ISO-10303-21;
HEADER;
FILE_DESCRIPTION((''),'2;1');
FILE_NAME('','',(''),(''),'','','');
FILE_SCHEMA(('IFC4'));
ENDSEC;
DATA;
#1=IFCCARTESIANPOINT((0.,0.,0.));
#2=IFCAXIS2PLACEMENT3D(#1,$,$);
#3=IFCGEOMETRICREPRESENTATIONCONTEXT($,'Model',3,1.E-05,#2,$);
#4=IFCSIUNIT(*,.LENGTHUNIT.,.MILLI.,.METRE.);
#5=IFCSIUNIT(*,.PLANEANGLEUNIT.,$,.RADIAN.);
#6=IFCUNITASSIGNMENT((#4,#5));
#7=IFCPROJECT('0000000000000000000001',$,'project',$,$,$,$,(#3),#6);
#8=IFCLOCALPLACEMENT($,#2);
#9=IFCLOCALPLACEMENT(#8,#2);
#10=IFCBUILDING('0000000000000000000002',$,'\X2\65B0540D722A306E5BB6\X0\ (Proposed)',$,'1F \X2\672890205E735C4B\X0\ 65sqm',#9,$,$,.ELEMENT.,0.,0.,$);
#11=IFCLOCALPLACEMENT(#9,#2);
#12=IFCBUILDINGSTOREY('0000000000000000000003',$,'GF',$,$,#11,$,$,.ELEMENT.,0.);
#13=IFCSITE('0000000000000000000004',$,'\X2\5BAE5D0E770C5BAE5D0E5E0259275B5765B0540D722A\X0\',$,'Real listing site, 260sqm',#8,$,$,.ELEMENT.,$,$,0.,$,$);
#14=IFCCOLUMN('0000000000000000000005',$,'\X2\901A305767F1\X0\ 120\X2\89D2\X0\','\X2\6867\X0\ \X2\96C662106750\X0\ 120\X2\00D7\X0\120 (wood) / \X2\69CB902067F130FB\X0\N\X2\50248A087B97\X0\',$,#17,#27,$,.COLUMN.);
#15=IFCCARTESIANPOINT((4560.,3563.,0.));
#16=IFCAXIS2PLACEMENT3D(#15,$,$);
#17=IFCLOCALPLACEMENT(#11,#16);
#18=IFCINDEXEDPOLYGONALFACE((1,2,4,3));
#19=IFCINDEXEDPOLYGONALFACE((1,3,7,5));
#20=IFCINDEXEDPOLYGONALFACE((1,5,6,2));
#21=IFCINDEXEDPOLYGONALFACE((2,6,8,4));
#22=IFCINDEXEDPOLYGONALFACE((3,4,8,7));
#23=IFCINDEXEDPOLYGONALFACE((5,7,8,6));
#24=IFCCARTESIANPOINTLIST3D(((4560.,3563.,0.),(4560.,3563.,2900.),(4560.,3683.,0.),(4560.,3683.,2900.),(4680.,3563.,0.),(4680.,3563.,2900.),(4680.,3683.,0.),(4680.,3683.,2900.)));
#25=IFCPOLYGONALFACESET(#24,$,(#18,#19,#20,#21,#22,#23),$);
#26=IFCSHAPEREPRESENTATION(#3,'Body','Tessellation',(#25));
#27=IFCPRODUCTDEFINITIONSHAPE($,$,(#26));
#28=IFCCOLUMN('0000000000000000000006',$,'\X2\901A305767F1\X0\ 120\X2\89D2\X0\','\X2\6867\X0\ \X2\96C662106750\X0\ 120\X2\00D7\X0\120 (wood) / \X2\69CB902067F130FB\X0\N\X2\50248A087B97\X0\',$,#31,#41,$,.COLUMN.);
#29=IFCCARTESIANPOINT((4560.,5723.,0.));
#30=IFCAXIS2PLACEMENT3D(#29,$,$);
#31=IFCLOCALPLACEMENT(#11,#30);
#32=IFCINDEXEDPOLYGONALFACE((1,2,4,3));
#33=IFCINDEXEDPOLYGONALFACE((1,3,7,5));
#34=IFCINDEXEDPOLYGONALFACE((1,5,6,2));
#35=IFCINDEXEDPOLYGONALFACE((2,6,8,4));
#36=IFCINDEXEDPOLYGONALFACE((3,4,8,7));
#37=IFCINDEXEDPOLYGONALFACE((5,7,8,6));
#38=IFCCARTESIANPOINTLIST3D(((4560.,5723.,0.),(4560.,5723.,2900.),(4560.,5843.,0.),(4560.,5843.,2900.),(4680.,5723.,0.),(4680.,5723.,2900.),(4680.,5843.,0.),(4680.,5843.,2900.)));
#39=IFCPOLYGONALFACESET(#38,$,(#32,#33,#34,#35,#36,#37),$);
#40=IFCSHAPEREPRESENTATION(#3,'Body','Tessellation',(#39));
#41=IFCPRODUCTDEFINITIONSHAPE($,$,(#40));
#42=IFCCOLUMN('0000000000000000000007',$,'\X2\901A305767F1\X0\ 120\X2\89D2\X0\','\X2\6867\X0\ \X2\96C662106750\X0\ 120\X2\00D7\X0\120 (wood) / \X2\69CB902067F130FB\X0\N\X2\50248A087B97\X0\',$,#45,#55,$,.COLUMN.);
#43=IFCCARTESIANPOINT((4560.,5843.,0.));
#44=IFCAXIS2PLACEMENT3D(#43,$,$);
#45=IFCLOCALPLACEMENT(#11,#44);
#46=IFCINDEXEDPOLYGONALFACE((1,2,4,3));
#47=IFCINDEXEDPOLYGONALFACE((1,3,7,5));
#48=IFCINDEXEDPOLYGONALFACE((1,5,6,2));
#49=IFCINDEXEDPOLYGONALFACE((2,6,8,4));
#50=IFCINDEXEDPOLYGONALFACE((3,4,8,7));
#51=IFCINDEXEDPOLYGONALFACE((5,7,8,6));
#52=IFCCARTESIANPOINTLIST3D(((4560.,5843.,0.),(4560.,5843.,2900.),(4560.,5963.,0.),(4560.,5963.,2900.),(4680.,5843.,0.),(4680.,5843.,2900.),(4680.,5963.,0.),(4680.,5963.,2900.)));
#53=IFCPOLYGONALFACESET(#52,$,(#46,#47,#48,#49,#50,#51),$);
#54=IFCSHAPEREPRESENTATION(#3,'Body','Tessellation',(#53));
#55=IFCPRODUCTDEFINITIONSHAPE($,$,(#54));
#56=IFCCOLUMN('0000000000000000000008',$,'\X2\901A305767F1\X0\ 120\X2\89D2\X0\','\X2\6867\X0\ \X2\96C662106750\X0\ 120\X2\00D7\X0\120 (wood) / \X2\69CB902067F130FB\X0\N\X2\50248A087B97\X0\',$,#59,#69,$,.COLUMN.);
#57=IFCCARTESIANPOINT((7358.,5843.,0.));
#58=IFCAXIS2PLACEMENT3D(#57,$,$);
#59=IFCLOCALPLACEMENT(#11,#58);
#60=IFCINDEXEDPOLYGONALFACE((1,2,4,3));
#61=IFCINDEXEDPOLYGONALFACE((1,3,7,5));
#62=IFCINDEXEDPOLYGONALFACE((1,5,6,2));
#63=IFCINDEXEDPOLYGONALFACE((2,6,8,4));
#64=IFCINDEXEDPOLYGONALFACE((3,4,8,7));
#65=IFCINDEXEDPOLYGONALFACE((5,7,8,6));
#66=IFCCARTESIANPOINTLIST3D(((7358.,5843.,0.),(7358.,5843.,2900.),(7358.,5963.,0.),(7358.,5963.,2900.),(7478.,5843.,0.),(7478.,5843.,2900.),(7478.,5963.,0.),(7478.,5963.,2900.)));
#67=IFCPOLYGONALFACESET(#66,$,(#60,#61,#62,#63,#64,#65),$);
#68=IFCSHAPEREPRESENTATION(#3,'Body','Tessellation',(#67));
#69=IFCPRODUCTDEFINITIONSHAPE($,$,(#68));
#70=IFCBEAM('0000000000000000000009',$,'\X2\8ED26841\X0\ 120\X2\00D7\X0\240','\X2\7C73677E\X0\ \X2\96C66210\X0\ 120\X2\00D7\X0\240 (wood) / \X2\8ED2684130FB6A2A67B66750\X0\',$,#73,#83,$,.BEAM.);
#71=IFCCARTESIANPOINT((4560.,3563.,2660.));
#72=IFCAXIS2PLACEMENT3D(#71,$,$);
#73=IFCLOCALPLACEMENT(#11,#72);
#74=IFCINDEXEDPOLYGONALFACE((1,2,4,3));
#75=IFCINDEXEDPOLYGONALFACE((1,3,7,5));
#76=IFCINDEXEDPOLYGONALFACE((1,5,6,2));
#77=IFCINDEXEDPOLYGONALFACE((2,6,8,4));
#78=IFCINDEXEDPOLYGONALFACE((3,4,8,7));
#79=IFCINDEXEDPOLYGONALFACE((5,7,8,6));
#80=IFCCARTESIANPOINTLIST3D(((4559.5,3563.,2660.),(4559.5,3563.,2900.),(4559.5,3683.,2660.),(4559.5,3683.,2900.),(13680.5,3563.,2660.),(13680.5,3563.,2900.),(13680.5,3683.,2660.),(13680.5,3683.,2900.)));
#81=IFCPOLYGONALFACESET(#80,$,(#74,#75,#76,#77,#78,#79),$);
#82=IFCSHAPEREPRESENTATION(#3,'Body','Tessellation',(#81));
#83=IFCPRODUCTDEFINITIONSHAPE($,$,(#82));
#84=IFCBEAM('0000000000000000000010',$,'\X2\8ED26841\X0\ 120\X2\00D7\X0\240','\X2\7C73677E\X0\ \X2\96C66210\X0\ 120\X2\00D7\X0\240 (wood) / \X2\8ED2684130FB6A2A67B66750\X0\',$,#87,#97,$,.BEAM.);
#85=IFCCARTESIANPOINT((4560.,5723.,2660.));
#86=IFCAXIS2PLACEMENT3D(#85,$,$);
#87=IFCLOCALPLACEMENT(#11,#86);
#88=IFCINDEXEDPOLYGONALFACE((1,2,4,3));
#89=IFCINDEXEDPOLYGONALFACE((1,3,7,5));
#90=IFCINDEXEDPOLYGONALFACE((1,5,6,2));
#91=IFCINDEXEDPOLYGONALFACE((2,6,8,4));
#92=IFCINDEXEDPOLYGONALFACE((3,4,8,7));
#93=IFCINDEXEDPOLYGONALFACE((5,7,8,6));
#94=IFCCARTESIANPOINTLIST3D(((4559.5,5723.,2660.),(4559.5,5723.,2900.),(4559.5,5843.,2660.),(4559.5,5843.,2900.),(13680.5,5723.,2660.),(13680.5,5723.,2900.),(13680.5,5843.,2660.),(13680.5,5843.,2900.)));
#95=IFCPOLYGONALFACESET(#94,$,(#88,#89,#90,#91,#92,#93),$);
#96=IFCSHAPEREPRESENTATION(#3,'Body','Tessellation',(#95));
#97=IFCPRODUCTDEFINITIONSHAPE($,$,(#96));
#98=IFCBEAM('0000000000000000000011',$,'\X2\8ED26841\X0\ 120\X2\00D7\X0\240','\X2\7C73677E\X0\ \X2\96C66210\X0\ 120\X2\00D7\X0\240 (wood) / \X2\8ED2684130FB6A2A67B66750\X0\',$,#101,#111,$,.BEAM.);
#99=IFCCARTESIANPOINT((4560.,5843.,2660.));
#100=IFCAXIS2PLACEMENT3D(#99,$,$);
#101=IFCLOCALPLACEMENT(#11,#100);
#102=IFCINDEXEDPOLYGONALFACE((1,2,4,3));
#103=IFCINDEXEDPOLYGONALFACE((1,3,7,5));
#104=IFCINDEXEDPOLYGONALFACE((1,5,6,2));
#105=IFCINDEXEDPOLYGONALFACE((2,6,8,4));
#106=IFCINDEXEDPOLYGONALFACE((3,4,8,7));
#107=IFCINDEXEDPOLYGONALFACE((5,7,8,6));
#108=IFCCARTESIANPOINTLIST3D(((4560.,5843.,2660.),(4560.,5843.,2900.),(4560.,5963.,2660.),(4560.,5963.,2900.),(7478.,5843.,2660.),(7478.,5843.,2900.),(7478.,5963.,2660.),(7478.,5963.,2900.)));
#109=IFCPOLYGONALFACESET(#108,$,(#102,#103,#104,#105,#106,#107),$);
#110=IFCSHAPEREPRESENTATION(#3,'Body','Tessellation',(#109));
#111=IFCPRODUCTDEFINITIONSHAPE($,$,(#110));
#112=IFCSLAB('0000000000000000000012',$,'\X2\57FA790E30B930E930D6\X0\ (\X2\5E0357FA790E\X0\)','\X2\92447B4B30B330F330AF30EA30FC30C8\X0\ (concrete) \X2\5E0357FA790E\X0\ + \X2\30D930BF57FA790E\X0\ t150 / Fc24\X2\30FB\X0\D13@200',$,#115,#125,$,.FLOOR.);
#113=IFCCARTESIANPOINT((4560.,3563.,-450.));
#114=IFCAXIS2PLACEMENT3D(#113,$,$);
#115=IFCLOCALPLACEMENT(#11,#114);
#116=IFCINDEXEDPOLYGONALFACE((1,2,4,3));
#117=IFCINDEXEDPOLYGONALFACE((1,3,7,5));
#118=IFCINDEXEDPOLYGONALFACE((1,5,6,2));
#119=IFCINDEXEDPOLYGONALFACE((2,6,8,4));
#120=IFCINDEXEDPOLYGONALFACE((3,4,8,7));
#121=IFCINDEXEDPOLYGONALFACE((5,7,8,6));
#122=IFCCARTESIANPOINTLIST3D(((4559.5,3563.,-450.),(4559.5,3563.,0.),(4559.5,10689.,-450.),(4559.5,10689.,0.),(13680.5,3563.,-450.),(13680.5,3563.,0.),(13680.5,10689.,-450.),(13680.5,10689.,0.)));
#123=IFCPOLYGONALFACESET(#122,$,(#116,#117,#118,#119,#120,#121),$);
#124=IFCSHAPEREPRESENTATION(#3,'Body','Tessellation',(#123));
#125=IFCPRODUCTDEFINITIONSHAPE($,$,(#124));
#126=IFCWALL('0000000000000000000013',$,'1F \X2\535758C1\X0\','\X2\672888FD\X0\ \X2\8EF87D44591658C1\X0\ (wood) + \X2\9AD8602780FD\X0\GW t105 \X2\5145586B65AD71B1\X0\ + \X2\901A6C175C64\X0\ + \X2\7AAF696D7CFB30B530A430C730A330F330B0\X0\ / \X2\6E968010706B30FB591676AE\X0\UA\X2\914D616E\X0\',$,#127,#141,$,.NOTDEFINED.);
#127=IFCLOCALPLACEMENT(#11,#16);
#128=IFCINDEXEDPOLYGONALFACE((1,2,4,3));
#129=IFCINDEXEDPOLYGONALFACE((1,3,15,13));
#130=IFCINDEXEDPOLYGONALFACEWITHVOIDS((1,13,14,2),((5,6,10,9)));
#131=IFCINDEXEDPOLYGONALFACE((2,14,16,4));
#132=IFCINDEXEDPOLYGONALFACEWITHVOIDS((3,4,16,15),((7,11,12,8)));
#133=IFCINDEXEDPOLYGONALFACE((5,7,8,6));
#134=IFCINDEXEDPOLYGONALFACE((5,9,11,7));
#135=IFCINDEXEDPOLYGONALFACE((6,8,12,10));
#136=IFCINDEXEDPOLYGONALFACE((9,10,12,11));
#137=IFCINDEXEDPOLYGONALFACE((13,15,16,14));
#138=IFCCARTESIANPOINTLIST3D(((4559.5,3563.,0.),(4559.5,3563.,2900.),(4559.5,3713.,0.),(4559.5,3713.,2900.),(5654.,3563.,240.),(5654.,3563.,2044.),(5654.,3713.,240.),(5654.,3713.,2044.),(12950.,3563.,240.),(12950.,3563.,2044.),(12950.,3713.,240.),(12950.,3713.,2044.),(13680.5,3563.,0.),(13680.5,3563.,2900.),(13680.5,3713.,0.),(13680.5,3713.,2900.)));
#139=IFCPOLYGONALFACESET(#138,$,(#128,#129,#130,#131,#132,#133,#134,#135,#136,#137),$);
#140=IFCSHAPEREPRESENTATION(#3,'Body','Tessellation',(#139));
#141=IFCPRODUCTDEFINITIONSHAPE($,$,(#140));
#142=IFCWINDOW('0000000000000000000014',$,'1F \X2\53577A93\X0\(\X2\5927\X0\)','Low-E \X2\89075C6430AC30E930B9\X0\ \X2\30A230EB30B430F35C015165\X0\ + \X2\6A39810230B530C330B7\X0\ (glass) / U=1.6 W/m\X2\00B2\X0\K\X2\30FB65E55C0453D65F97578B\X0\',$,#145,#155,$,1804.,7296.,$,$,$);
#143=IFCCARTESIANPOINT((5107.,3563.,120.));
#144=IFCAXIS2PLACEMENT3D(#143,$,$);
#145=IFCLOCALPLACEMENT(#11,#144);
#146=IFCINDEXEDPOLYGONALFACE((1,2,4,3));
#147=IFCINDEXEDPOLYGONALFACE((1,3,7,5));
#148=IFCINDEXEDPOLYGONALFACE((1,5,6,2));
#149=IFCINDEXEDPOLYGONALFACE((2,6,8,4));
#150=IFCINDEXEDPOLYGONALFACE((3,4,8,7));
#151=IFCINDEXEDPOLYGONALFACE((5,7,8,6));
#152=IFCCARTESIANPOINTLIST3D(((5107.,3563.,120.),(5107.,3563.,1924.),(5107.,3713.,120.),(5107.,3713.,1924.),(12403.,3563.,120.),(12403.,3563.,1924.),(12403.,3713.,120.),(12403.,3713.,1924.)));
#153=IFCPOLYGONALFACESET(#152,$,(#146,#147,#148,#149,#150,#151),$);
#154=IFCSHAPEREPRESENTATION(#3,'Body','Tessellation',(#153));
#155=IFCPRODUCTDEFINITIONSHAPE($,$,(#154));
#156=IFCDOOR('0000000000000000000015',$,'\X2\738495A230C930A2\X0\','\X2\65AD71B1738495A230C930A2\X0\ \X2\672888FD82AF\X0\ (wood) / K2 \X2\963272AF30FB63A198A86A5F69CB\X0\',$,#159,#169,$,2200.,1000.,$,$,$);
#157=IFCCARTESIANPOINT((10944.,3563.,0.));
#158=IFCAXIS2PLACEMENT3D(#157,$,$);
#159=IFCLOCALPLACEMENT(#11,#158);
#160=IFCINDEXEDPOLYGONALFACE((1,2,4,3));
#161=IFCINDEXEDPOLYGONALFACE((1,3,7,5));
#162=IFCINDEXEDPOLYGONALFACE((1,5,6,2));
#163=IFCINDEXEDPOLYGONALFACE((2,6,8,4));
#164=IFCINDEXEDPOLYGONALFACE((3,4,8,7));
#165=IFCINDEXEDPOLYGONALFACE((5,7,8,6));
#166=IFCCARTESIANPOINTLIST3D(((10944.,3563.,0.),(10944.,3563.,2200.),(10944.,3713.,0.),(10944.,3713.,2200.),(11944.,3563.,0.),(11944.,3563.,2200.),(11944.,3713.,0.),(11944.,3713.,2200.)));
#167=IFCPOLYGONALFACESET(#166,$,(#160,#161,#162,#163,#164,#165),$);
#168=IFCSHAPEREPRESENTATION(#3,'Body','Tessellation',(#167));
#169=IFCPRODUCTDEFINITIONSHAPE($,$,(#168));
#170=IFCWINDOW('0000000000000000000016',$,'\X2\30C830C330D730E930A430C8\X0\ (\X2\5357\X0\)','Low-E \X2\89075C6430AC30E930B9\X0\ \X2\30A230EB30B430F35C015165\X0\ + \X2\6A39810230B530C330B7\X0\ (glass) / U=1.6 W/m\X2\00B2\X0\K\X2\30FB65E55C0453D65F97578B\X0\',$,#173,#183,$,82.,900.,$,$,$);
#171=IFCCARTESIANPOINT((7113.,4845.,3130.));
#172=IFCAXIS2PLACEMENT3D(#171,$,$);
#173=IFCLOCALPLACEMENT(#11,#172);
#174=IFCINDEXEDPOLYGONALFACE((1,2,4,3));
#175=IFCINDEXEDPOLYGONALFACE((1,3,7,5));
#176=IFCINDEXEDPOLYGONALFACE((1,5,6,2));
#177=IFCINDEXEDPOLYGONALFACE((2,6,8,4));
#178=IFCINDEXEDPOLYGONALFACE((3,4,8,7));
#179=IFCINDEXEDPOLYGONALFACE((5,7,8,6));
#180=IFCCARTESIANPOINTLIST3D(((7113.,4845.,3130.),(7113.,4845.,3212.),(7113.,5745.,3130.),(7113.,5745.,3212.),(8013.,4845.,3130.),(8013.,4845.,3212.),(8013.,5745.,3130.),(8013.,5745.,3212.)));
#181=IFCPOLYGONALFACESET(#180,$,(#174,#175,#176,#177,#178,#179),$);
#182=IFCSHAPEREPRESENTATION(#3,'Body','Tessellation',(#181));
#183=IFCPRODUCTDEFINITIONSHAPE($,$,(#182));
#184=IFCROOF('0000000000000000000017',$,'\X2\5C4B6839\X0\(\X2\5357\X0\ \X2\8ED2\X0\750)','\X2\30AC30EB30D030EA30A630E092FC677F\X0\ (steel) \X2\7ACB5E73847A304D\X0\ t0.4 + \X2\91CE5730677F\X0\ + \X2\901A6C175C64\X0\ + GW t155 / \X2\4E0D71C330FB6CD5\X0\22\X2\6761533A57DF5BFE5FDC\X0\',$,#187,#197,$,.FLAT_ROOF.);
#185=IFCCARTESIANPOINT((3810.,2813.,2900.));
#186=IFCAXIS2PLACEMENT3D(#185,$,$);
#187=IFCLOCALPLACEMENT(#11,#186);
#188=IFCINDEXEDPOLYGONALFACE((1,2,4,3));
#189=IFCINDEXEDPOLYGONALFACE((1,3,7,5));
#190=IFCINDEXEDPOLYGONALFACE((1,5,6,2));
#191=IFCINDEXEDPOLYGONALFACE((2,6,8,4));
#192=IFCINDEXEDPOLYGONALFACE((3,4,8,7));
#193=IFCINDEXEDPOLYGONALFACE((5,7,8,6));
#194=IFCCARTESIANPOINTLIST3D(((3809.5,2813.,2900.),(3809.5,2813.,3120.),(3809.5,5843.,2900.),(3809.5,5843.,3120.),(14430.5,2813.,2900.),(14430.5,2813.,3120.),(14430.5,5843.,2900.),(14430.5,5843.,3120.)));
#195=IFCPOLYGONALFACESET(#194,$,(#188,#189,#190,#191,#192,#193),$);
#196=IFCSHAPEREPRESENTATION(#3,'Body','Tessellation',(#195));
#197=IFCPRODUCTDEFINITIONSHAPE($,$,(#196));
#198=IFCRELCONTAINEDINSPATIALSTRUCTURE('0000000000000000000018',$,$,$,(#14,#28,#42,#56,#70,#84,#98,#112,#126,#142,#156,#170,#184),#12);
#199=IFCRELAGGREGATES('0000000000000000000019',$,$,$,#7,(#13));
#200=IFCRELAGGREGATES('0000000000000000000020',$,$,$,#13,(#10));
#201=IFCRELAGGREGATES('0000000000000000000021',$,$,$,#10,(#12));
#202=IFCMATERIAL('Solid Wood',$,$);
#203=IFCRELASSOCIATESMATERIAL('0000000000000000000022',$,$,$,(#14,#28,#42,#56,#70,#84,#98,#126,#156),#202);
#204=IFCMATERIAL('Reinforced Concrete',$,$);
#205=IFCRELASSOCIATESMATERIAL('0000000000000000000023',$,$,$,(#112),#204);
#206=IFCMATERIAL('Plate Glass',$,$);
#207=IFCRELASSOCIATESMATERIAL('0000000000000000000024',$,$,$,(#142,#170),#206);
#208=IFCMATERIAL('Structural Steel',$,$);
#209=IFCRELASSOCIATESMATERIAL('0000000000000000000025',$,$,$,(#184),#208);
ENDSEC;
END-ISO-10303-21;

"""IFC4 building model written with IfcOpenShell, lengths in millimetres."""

from ifc_helpers import new_model, si_unit, frame, frame_2d, origin, place, context, project, spatial, rectangle, extrude, material, element, fill, save


model = new_model("IFC4")

# Units and contexts
model_context = context("Model", 3, precision=1e-05, world=origin())
ifc_project = project(units=[si_unit("LENGTHUNIT", "METRE", prefix="MILLI"), si_unit("PLANEANGLEUNIT", "RADIAN")], contexts=[model_context])

# Site, building, storey
site_placement = place(None, origin())
site = spatial("IfcSite", under=ifc_project, at=site_placement, Name="宮崎県宮崎市大字新名爪", ObjectType="Real listing site, 260sqm", CompositionType="ELEMENT", RefElevation=0.0)
building_placement = place(site_placement, origin())
building = spatial("IfcBuilding", under=site, at=building_placement, Name="新名爪の家 (Proposed)", ObjectType="1F 木造平屋 65sqm", CompositionType="ELEMENT", ElevationOfRefHeight=0.0, ElevationOfTerrain=0.0)
storey_placement = place(building_placement, origin())
storey = spatial("IfcBuildingStorey", under=building, at=storey_placement, Name="GF", CompositionType="ELEMENT", Elevation=0.0)

# Columns
ifc_material_1 = material(Name="Solid Wood")
column_1_placement = place(storey_placement, frame((4560.0, 3563.0, 0.0)))
element("IfcColumn", 1, at=column_1_placement, inside=storey, material=ifc_material_1, Name="通し柱 120角", Description="桧 集成材 120×120 (wood) / 構造柱・N値計算", PredefinedType="COLUMN", context=model_context, shape_type="SweptSolid", body=[
    extrude(rectangle(XDim=120.0, YDim=120.0, at=frame_2d((60.0, 60.0))), frame((4560.0, 3563.0, 0.0)), (0.0, 0.0, 1.0), 2900.0),
])
column_2_placement = place(storey_placement, frame((4560.0, 5723.0, 0.0)))
element("IfcColumn", 2, at=column_2_placement, inside=storey, material=ifc_material_1, Name="通し柱 120角", Description="桧 集成材 120×120 (wood) / 構造柱・N値計算", PredefinedType="COLUMN", context=model_context, shape_type="SweptSolid", body=[
    extrude(rectangle(XDim=120.0, YDim=120.0, at=frame_2d((60.0, 60.0))), frame((4560.0, 5723.0, 0.0)), (0.0, 0.0, 1.0), 2900.0),
])
column_3_placement = place(storey_placement, frame((4560.0, 5843.0, 0.0)))
element("IfcColumn", 3, at=column_3_placement, inside=storey, material=ifc_material_1, Name="通し柱 120角", Description="桧 集成材 120×120 (wood) / 構造柱・N値計算", PredefinedType="COLUMN", context=model_context, shape_type="SweptSolid", body=[
    extrude(rectangle(XDim=120.0, YDim=120.0, at=frame_2d((60.0, 60.0))), frame((4560.0, 5843.0, 0.0)), (0.0, 0.0, 1.0), 2900.0),
])
column_4_placement = place(storey_placement, frame((7358.0, 5843.0, 0.0)))
element("IfcColumn", 4, at=column_4_placement, inside=storey, material=ifc_material_1, Name="通し柱 120角", Description="桧 集成材 120×120 (wood) / 構造柱・N値計算", PredefinedType="COLUMN", context=model_context, shape_type="SweptSolid", body=[
    extrude(rectangle(XDim=120.0, YDim=120.0, at=frame_2d((60.0, 60.0))), frame((7358.0, 5843.0, 0.0)), (0.0, 0.0, 1.0), 2900.0),
])

# Beams
beam_1_placement = place(storey_placement, frame((4560.0, 3563.0, 2660.0)))
element("IfcBeam", 5, at=beam_1_placement, inside=storey, material=ifc_material_1, Name="軒桁 120×240", Description="米松 集成 120×240 (wood) / 軒桁・横架材", PredefinedType="BEAM", context=model_context, shape_type="SweptSolid", body=[
    extrude(rectangle(XDim=9121.0, YDim=120.0, at=frame_2d((4560.0, 60.0))), frame((4560.0, 3563.0, 2660.0)), (0.0, 0.0, 1.0), 240.0),
])
beam_2_placement = place(storey_placement, frame((4560.0, 5723.0, 2660.0)))
element("IfcBeam", 6, at=beam_2_placement, inside=storey, material=ifc_material_1, Name="軒桁 120×240", Description="米松 集成 120×240 (wood) / 軒桁・横架材", PredefinedType="BEAM", context=model_context, shape_type="SweptSolid", body=[
    extrude(rectangle(XDim=9121.0, YDim=120.0, at=frame_2d((4560.0, 60.0))), frame((4560.0, 5723.0, 2660.0)), (0.0, 0.0, 1.0), 240.0),
])
beam_3_placement = place(storey_placement, frame((4560.0, 5843.0, 2660.0)))
element("IfcBeam", 7, at=beam_3_placement, inside=storey, material=ifc_material_1, Name="軒桁 120×240", Description="米松 集成 120×240 (wood) / 軒桁・横架材", PredefinedType="BEAM", context=model_context, shape_type="SweptSolid", body=[
    extrude(rectangle(XDim=2918.0, YDim=120.0, at=frame_2d((1459.0, 60.0))), frame((4560.0, 5843.0, 2660.0)), (0.0, 0.0, 1.0), 240.0),
])

# Slab
ifc_material_2 = material(Name="Reinforced Concrete")
slab_1_placement = place(storey_placement, frame((4560.0, 3563.0, -450.0)))
element("IfcSlab", 8, at=slab_1_placement, inside=storey, material=ifc_material_2, Name="基礎スラブ (布基礎)", Description="鉄筋コンクリート (concrete) 布基礎 + ベタ基礎 t150 / Fc24・D13@200", PredefinedType="FLOOR", context=model_context, shape_type="SweptSolid", body=[
    extrude(rectangle(XDim=9121.0, YDim=7126.0, at=frame_2d((4560.0, 3563.0))), frame((4560.0, 3563.0, -450.0)), (0.0, 0.0, 1.0), 450.0),
])

# Wall, openings, window, door
wall_1_placement = place(storey_placement, frame((4560.0, 3563.0, 0.0)))
wall_1 = element("IfcWall", 9, at=wall_1_placement, inside=storey, material=ifc_material_1, Name="1F 南壁", Description="木製 軸組外壁 (wood) + 高性能GW t105 充填断熱 + 通気層 + 窯業系サイディング / 準耐火・外皮UA配慮", PredefinedType="NOTDEFINED", context=model_context, shape_type="SweptSolid", body=[
    extrude(rectangle(XDim=9121.0, YDim=150.0, at=frame_2d((4560.0, 75.0))), frame((4560.0, 3563.0, 0.0)), (0.0, 0.0, 1.0), 2900.0),
])
opening_1_placement = place(storey_placement, frame((5107.0, 3563.0, 120.0)))
opening_1 = element("IfcOpeningElement", 10, at=opening_1_placement, cuts=wall_1, PredefinedType="NOTDEFINED", context=model_context, shape_type="SweptSolid", body=[
    extrude(rectangle(XDim=7296.0, YDim=150.0, at=frame_2d((3648.0, 75.0))), frame((5107.0, 3563.0, 120.0)), (0.0, 0.0, 1.0), 1804.0),
])
opening_2_placement = place(storey_placement, frame((10944.0, 3563.0, 0.0)))
opening_2 = element("IfcOpeningElement", 11, at=opening_2_placement, cuts=wall_1, PredefinedType="NOTDEFINED", context=model_context, shape_type="SweptSolid", body=[
    extrude(rectangle(XDim=1000.0, YDim=150.0, at=frame_2d((500.0, 75.0))), frame((10944.0, 3563.0, 0.0)), (0.0, 0.0, 1.0), 2200.0),
])
ifc_material_3 = material(Name="Plate Glass")
window_1_placement = place(storey_placement, frame((5107.0, 3563.0, 120.0)))
window_1 = element("IfcWindow", 12, at=window_1_placement, inside=storey, material=ifc_material_3, Name="1F 南窓(大)", Description="Low-E 複層ガラス アルゴン封入 + 樹脂サッシ (glass) / U=1.6 W/m²K・日射取得型", OverallHeight=1804.0, OverallWidth=7296.0, context=model_context, shape_type="SweptSolid", body=[
    extrude(rectangle(XDim=7296.0, YDim=150.0, at=frame_2d((3648.0, 75.0))), frame((5107.0, 3563.0, 120.0)), (0.0, 0.0, 1.0), 1804.0),
])
fill(opening_1, window_1)
door_placement = place(storey_placement, frame((10944.0, 3563.0, 0.0)))
door = element("IfcDoor", 13, at=door_placement, inside=storey, material=ifc_material_1, Name="玄関ドア", Description="断熱玄関ドア 木製芯 (wood) / K2 防犯・採風機構", OverallHeight=2200.0, OverallWidth=1000.0, context=model_context, shape_type="SweptSolid", body=[
    extrude(rectangle(XDim=1000.0, YDim=150.0, at=frame_2d((500.0, 75.0))), frame((10944.0, 3563.0, 0.0)), (0.0, 0.0, 1.0), 2200.0),
])
fill(opening_2, door)

# Window
window_2_placement = place(storey_placement, frame((7113.0, 4845.0, 3130.0)))
element("IfcWindow", 14, at=window_2_placement, inside=storey, material=ifc_material_3, Name="トップライト (南)", Description="Low-E 複層ガラス アルゴン封入 + 樹脂サッシ (glass) / U=1.6 W/m²K・日射取得型", OverallHeight=82.0, OverallWidth=900.0, context=model_context, shape_type="SweptSolid", body=[
    extrude(rectangle(XDim=900.0, YDim=900.0, at=frame_2d((450.0, 450.0))), frame((7113.0, 4845.0, 3130.0)), (0.0, 0.0, 1.0), 82.0),
])

# Roof
ifc_material_4 = material(Name="Structural Steel")
roof_1_placement = place(storey_placement, frame((3810.0, 2813.0, 2900.0)))
element("IfcRoof", 15, at=roof_1_placement, inside=storey, material=ifc_material_4, Name="屋根(南 軒750)", Description="ガルバリウム鋼板 (steel) 立平葺き t0.4 + 野地板 + 通気層 + GW t155 / 不燃・法22条区域対応", PredefinedType="FLAT_ROOF", context=model_context, shape_type="SweptSolid", body=[
    extrude(rectangle(XDim=10621.0, YDim=3030.0, at=frame_2d((5310.0, 1515.0))), frame((3810.0, 2813.0, 2900.0)), (0.0, 0.0, 1.0), 220.0),
])

save(model, "model.ifc")
